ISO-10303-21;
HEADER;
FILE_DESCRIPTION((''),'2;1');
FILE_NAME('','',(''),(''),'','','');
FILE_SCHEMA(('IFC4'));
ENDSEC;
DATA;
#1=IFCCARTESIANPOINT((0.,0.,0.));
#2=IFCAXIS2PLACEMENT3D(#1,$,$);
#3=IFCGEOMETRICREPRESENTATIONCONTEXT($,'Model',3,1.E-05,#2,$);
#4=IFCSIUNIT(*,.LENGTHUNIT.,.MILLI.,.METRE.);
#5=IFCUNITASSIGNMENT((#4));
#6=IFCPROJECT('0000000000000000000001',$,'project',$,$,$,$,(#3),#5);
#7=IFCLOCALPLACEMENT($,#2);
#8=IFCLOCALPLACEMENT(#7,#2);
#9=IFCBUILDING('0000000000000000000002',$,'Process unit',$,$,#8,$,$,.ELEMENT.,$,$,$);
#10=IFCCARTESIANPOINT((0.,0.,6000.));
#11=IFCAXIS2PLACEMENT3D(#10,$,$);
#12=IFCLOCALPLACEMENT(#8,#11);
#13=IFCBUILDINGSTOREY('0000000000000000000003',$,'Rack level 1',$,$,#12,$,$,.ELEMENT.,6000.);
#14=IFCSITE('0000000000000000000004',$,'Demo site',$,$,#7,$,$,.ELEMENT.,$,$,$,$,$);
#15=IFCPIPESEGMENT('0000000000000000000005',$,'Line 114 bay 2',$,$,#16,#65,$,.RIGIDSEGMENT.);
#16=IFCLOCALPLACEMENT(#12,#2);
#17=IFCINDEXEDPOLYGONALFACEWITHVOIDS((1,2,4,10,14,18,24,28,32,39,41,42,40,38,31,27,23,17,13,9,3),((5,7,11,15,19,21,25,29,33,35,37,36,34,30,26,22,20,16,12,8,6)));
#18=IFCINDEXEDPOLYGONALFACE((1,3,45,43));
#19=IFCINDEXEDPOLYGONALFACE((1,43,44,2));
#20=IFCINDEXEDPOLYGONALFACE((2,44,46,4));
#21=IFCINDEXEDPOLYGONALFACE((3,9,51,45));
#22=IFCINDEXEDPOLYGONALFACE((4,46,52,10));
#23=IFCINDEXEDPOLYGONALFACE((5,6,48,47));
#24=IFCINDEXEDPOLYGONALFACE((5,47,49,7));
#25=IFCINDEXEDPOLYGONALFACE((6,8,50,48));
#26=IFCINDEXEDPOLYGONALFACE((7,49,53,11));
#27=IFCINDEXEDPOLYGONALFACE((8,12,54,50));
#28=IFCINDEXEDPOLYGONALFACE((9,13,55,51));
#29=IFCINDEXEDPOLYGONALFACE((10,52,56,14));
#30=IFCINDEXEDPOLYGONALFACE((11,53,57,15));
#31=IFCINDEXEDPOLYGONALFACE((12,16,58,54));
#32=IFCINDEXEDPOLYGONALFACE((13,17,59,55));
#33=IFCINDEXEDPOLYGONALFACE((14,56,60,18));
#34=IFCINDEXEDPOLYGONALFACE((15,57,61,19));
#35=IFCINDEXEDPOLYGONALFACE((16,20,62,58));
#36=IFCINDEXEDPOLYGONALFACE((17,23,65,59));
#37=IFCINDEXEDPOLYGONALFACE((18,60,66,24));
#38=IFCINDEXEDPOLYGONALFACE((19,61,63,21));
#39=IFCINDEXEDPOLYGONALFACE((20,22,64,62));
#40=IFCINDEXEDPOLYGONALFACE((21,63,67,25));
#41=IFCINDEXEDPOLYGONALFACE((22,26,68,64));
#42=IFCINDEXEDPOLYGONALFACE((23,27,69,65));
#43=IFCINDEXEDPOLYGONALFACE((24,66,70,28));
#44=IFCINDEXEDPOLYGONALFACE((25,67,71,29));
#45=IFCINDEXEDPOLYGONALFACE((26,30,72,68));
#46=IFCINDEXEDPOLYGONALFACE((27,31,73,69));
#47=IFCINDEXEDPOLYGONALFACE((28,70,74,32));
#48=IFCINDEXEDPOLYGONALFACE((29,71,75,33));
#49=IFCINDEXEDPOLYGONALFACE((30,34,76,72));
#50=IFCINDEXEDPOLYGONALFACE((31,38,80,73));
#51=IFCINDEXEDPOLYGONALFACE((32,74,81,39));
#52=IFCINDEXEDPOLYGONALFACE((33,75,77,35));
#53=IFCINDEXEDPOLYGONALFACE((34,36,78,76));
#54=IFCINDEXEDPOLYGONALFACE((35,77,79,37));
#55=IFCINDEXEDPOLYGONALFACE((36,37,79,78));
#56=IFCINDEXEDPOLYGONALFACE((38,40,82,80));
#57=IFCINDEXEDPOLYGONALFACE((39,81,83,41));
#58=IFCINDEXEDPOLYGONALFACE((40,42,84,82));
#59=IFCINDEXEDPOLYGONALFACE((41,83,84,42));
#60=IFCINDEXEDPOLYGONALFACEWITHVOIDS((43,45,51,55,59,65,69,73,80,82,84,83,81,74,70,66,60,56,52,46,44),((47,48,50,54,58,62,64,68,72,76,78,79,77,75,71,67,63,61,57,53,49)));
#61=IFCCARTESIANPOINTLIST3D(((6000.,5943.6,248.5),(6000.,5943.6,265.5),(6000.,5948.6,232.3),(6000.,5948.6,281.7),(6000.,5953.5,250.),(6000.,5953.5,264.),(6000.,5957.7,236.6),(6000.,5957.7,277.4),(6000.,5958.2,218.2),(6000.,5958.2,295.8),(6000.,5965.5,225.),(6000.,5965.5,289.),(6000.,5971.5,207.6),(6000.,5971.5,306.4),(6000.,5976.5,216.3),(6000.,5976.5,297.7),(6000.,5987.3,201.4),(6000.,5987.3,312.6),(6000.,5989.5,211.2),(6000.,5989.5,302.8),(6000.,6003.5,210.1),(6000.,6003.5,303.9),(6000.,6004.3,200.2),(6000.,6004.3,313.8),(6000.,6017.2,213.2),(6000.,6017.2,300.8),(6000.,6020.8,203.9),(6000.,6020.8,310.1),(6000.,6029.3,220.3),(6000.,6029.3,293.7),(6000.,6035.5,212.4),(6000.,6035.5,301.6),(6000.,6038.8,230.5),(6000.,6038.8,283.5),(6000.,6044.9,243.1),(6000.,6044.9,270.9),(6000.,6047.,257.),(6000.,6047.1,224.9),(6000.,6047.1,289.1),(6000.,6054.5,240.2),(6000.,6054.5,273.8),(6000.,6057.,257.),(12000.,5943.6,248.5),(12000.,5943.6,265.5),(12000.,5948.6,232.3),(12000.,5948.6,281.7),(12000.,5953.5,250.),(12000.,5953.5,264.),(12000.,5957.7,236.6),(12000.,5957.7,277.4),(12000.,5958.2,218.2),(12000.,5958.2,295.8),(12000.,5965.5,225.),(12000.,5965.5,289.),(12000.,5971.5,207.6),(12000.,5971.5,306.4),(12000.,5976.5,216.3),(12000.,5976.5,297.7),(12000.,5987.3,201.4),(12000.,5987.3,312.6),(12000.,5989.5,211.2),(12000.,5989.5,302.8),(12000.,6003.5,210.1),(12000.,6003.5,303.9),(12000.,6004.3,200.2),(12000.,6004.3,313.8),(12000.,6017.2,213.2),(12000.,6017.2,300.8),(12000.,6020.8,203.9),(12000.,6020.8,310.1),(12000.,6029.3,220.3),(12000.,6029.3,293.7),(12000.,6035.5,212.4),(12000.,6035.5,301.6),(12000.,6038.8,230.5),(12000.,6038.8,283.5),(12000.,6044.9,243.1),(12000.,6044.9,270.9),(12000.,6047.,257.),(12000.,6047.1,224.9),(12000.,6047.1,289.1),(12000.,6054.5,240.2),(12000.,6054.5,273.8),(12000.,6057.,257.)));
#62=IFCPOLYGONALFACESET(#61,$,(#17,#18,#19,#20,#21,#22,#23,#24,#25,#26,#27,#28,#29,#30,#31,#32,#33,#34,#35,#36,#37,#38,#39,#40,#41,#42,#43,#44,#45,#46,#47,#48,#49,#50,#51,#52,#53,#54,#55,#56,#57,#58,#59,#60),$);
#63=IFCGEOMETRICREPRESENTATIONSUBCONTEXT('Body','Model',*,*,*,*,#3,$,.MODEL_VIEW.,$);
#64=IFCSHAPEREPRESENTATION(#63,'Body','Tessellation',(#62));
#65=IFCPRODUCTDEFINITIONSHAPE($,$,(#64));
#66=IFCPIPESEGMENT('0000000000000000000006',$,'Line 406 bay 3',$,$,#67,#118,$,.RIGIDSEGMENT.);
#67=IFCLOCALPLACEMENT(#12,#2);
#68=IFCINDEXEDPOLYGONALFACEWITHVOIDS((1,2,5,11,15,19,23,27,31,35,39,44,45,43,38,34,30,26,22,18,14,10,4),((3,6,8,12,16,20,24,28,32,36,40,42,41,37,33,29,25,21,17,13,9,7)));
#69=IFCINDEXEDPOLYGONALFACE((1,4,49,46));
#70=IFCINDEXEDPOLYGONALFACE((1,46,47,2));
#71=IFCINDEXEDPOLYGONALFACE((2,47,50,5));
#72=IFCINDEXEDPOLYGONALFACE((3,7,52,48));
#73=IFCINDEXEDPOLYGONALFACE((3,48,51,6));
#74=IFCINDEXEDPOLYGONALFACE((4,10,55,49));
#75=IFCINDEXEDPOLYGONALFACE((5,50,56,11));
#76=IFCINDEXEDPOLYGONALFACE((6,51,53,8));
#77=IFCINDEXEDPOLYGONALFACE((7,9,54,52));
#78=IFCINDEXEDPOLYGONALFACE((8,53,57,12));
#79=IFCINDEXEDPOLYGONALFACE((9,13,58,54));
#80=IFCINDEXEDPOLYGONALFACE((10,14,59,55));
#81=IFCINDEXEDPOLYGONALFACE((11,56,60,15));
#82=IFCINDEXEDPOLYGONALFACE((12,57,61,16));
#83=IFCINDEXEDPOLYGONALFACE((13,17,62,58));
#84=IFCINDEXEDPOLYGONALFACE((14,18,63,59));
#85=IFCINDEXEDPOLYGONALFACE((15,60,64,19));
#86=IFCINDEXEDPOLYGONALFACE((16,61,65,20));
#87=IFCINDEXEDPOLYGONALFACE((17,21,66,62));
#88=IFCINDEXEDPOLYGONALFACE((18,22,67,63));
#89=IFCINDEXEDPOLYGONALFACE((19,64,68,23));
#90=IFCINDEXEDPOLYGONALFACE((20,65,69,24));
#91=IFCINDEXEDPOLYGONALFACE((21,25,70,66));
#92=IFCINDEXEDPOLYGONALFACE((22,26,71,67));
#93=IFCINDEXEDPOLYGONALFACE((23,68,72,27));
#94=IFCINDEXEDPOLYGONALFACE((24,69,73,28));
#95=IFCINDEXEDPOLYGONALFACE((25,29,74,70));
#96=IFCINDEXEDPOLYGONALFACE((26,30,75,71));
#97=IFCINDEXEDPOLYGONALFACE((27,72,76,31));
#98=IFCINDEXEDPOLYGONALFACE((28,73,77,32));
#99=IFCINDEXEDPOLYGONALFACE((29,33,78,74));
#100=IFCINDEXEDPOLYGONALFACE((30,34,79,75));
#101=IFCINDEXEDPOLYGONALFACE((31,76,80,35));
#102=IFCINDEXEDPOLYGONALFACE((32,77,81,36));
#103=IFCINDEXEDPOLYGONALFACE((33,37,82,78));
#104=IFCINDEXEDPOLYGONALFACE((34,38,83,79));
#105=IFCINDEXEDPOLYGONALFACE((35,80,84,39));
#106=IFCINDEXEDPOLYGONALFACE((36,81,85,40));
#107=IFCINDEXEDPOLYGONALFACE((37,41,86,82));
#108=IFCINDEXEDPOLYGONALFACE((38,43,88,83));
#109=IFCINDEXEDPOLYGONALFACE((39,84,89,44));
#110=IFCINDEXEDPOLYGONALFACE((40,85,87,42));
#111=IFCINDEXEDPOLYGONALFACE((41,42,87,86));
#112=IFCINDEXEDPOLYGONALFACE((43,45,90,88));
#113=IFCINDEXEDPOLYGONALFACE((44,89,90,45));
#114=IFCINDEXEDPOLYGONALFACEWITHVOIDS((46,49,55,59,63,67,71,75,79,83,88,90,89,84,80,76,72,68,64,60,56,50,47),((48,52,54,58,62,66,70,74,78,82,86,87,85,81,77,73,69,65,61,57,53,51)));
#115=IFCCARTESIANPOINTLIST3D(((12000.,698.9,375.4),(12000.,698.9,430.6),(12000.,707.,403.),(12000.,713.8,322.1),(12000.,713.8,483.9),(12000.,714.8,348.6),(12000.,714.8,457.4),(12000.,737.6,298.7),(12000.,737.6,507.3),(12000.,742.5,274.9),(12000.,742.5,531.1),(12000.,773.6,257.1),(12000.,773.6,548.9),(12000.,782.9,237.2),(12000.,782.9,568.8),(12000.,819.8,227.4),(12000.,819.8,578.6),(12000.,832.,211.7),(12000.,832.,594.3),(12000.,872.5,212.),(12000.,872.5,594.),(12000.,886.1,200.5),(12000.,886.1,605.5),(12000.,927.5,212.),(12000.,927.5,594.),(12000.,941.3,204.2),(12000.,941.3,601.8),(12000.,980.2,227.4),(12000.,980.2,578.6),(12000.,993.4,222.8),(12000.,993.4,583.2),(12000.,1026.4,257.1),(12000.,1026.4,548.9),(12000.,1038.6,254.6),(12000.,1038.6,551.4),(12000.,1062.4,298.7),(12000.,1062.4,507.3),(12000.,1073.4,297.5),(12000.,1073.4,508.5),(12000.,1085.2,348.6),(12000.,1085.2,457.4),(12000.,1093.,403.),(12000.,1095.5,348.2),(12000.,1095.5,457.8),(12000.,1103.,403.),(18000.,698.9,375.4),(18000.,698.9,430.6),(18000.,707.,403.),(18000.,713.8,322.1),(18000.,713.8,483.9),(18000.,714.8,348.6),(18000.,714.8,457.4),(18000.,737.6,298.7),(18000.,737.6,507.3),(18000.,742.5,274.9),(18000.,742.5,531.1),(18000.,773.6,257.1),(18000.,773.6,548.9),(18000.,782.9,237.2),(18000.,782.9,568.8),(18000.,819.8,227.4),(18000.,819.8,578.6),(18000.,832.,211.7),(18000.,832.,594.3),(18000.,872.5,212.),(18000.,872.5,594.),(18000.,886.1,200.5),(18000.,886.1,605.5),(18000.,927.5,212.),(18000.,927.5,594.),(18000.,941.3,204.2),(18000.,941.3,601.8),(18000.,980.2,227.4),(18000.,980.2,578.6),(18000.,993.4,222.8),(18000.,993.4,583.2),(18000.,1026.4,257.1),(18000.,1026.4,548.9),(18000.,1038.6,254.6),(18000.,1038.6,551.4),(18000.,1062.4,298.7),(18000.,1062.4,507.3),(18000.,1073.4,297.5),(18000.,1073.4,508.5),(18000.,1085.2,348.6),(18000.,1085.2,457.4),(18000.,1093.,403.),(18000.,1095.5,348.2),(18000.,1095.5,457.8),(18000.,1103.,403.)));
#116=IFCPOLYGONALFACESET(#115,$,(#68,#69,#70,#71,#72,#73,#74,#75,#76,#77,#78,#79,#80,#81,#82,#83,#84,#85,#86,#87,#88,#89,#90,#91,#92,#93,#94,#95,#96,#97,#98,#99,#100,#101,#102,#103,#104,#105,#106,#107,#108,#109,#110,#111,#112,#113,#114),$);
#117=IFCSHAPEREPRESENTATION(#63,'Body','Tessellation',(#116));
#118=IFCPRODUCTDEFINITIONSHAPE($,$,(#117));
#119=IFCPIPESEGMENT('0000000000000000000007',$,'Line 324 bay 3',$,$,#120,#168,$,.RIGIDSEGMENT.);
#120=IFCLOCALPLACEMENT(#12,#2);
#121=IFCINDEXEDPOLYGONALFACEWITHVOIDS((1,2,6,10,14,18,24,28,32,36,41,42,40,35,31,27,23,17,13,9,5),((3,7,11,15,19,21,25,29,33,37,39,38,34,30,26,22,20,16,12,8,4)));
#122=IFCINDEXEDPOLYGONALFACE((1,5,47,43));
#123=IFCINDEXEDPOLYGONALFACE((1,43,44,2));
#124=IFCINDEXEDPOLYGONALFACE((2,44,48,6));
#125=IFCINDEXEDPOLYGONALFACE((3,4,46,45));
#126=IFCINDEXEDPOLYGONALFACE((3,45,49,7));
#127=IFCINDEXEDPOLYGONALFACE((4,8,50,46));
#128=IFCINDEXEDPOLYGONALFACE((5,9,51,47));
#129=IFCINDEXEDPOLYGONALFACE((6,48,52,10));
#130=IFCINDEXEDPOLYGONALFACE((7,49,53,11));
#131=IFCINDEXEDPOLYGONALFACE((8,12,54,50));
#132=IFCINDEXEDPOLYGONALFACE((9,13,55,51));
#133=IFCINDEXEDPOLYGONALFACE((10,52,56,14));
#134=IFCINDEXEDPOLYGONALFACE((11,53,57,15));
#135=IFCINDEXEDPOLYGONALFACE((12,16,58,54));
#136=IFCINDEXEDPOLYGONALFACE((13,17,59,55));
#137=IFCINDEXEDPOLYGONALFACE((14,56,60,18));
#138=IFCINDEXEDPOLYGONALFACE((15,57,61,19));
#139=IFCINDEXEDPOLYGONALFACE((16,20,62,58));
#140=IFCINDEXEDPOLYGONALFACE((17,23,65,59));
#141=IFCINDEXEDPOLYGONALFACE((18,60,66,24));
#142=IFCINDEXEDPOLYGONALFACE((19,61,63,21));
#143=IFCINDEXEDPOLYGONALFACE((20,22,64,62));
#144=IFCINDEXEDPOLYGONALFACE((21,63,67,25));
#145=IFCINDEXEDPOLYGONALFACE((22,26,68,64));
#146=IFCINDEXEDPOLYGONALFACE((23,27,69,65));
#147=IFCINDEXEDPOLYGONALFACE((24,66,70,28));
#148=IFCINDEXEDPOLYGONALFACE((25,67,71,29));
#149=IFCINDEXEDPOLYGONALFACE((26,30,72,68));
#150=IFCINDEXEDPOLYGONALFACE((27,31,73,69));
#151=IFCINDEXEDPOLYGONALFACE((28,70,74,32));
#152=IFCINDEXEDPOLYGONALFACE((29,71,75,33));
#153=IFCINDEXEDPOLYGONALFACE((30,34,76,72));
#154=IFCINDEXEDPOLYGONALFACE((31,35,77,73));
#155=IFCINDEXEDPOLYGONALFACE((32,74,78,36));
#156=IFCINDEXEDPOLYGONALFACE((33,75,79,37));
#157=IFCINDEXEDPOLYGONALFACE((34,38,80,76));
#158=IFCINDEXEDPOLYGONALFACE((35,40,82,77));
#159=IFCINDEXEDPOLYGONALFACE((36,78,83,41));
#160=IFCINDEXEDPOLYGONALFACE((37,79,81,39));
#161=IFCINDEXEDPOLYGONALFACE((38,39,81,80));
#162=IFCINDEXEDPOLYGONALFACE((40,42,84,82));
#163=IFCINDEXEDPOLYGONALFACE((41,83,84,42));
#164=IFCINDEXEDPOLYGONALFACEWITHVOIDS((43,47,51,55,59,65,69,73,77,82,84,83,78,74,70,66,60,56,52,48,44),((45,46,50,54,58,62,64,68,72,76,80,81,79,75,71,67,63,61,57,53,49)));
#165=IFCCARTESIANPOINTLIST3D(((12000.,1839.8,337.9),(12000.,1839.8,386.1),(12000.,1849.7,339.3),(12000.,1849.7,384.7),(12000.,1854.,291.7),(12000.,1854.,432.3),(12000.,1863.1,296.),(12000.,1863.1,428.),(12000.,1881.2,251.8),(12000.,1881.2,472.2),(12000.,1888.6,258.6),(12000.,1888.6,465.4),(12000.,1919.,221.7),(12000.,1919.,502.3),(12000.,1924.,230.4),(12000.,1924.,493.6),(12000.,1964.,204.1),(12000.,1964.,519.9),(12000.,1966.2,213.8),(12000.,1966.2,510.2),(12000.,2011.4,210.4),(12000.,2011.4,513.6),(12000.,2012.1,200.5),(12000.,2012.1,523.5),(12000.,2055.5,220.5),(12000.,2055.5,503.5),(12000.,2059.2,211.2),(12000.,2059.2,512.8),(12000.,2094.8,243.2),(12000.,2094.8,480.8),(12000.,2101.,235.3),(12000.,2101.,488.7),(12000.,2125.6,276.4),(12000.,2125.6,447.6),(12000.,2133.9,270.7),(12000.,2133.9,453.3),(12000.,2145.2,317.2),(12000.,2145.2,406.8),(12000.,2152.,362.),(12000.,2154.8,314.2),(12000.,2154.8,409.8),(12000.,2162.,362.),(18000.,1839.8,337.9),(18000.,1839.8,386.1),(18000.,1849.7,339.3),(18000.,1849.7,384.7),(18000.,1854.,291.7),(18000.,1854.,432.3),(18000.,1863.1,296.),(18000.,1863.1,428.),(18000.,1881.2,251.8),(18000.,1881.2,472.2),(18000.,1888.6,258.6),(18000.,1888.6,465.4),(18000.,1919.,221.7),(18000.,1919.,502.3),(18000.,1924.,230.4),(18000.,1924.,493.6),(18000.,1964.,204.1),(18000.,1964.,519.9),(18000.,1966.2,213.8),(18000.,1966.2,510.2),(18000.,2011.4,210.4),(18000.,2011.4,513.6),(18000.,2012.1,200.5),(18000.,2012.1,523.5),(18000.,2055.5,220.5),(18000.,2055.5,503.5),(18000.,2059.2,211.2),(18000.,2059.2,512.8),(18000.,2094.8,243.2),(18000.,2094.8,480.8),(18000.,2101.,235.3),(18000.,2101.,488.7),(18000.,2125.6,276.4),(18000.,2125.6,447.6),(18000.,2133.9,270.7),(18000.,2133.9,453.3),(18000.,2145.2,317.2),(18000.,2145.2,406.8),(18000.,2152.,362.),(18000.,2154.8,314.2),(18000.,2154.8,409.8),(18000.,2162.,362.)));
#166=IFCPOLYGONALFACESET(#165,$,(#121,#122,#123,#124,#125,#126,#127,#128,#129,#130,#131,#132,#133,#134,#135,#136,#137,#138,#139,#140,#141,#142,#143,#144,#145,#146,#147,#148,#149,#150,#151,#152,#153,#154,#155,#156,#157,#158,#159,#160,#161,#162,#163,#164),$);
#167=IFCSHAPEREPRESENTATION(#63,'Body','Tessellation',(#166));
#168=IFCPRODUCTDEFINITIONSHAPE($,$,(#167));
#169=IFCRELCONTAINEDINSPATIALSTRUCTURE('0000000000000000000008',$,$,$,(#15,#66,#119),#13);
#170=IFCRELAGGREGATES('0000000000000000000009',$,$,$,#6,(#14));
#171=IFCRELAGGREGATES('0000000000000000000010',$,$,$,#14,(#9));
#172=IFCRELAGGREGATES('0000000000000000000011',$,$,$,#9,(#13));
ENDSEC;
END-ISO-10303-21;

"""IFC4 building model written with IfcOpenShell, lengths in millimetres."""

from ifc_helpers import new_model, si_unit, frame, origin, place, context, subcontext, project, spatial, hollow_circle, extrude, element, save


model = new_model("IFC4")

# Units and contexts
model_context = context("Model", 3, precision=1e-05, world=origin())
body_context = subcontext(model_context, "Body", "Model", "MODEL_VIEW")
ifc_project = project(units=[si_unit("LENGTHUNIT", "METRE", prefix="MILLI")], contexts=[model_context])

# Site, building, storey
site_placement = place(None, origin())
site = spatial("IfcSite", under=ifc_project, at=site_placement, Name="Demo site", CompositionType="ELEMENT")
building_placement = place(site_placement, origin())
building = spatial("IfcBuilding", under=site, at=building_placement, Name="Process unit", CompositionType="ELEMENT")
storey_placement = place(building_placement, frame((0.0, 0.0, 6000.0)))
storey = spatial("IfcBuildingStorey", under=building, at=storey_placement, Name="Rack level 1", CompositionType="ELEMENT", Elevation=6000.0)

# Pipe segments
pipe_segment_1_placement = place(storey_placement, frame((6000.0, 6000.0, 257.0)))
element("IfcPipeSegment", 1, at=pipe_segment_1_placement, inside=storey, Name="Line 114 bay 2", PredefinedType="RIGIDSEGMENT", context=body_context, shape_type="SweptSolid", body=[
    extrude(hollow_circle(Radius=57.0, WallThickness=10.0), frame((0.0, 0.0, 0.0), z_axis=(1.0, 0.0, 0.0), x_axis=(0.0, 1.0, 0.0)), (0.0, 0.0, 1.0), 6000.0),
])
pipe_segment_2_placement = place(storey_placement, frame((12000.0, 900.0, 403.0)))
element("IfcPipeSegment", 2, at=pipe_segment_2_placement, inside=storey, Name="Line 406 bay 3", PredefinedType="RIGIDSEGMENT", context=body_context, shape_type="SweptSolid", body=[
    extrude(hollow_circle(Radius=203.0, WallThickness=10.0), frame((0.0, 0.0, 0.0), z_axis=(1.0, 0.0, 0.0), x_axis=(0.0, 1.0, 0.0)), (0.0, 0.0, 1.0), 6000.0),
])
pipe_segment_3_placement = place(storey_placement, frame((12000.0, 2000.0, 362.0)))
element("IfcPipeSegment", 3, at=pipe_segment_3_placement, inside=storey, Name="Line 324 bay 3", PredefinedType="RIGIDSEGMENT", context=body_context, shape_type="SweptSolid", body=[
    extrude(hollow_circle(Radius=162.0, WallThickness=10.0), frame((0.0, 0.0, 0.0), z_axis=(1.0, 0.0, 0.0), x_axis=(0.0, 1.0, 0.0)), (0.0, 0.0, 1.0), 6000.0),
])

save(model, "model.ifc")
